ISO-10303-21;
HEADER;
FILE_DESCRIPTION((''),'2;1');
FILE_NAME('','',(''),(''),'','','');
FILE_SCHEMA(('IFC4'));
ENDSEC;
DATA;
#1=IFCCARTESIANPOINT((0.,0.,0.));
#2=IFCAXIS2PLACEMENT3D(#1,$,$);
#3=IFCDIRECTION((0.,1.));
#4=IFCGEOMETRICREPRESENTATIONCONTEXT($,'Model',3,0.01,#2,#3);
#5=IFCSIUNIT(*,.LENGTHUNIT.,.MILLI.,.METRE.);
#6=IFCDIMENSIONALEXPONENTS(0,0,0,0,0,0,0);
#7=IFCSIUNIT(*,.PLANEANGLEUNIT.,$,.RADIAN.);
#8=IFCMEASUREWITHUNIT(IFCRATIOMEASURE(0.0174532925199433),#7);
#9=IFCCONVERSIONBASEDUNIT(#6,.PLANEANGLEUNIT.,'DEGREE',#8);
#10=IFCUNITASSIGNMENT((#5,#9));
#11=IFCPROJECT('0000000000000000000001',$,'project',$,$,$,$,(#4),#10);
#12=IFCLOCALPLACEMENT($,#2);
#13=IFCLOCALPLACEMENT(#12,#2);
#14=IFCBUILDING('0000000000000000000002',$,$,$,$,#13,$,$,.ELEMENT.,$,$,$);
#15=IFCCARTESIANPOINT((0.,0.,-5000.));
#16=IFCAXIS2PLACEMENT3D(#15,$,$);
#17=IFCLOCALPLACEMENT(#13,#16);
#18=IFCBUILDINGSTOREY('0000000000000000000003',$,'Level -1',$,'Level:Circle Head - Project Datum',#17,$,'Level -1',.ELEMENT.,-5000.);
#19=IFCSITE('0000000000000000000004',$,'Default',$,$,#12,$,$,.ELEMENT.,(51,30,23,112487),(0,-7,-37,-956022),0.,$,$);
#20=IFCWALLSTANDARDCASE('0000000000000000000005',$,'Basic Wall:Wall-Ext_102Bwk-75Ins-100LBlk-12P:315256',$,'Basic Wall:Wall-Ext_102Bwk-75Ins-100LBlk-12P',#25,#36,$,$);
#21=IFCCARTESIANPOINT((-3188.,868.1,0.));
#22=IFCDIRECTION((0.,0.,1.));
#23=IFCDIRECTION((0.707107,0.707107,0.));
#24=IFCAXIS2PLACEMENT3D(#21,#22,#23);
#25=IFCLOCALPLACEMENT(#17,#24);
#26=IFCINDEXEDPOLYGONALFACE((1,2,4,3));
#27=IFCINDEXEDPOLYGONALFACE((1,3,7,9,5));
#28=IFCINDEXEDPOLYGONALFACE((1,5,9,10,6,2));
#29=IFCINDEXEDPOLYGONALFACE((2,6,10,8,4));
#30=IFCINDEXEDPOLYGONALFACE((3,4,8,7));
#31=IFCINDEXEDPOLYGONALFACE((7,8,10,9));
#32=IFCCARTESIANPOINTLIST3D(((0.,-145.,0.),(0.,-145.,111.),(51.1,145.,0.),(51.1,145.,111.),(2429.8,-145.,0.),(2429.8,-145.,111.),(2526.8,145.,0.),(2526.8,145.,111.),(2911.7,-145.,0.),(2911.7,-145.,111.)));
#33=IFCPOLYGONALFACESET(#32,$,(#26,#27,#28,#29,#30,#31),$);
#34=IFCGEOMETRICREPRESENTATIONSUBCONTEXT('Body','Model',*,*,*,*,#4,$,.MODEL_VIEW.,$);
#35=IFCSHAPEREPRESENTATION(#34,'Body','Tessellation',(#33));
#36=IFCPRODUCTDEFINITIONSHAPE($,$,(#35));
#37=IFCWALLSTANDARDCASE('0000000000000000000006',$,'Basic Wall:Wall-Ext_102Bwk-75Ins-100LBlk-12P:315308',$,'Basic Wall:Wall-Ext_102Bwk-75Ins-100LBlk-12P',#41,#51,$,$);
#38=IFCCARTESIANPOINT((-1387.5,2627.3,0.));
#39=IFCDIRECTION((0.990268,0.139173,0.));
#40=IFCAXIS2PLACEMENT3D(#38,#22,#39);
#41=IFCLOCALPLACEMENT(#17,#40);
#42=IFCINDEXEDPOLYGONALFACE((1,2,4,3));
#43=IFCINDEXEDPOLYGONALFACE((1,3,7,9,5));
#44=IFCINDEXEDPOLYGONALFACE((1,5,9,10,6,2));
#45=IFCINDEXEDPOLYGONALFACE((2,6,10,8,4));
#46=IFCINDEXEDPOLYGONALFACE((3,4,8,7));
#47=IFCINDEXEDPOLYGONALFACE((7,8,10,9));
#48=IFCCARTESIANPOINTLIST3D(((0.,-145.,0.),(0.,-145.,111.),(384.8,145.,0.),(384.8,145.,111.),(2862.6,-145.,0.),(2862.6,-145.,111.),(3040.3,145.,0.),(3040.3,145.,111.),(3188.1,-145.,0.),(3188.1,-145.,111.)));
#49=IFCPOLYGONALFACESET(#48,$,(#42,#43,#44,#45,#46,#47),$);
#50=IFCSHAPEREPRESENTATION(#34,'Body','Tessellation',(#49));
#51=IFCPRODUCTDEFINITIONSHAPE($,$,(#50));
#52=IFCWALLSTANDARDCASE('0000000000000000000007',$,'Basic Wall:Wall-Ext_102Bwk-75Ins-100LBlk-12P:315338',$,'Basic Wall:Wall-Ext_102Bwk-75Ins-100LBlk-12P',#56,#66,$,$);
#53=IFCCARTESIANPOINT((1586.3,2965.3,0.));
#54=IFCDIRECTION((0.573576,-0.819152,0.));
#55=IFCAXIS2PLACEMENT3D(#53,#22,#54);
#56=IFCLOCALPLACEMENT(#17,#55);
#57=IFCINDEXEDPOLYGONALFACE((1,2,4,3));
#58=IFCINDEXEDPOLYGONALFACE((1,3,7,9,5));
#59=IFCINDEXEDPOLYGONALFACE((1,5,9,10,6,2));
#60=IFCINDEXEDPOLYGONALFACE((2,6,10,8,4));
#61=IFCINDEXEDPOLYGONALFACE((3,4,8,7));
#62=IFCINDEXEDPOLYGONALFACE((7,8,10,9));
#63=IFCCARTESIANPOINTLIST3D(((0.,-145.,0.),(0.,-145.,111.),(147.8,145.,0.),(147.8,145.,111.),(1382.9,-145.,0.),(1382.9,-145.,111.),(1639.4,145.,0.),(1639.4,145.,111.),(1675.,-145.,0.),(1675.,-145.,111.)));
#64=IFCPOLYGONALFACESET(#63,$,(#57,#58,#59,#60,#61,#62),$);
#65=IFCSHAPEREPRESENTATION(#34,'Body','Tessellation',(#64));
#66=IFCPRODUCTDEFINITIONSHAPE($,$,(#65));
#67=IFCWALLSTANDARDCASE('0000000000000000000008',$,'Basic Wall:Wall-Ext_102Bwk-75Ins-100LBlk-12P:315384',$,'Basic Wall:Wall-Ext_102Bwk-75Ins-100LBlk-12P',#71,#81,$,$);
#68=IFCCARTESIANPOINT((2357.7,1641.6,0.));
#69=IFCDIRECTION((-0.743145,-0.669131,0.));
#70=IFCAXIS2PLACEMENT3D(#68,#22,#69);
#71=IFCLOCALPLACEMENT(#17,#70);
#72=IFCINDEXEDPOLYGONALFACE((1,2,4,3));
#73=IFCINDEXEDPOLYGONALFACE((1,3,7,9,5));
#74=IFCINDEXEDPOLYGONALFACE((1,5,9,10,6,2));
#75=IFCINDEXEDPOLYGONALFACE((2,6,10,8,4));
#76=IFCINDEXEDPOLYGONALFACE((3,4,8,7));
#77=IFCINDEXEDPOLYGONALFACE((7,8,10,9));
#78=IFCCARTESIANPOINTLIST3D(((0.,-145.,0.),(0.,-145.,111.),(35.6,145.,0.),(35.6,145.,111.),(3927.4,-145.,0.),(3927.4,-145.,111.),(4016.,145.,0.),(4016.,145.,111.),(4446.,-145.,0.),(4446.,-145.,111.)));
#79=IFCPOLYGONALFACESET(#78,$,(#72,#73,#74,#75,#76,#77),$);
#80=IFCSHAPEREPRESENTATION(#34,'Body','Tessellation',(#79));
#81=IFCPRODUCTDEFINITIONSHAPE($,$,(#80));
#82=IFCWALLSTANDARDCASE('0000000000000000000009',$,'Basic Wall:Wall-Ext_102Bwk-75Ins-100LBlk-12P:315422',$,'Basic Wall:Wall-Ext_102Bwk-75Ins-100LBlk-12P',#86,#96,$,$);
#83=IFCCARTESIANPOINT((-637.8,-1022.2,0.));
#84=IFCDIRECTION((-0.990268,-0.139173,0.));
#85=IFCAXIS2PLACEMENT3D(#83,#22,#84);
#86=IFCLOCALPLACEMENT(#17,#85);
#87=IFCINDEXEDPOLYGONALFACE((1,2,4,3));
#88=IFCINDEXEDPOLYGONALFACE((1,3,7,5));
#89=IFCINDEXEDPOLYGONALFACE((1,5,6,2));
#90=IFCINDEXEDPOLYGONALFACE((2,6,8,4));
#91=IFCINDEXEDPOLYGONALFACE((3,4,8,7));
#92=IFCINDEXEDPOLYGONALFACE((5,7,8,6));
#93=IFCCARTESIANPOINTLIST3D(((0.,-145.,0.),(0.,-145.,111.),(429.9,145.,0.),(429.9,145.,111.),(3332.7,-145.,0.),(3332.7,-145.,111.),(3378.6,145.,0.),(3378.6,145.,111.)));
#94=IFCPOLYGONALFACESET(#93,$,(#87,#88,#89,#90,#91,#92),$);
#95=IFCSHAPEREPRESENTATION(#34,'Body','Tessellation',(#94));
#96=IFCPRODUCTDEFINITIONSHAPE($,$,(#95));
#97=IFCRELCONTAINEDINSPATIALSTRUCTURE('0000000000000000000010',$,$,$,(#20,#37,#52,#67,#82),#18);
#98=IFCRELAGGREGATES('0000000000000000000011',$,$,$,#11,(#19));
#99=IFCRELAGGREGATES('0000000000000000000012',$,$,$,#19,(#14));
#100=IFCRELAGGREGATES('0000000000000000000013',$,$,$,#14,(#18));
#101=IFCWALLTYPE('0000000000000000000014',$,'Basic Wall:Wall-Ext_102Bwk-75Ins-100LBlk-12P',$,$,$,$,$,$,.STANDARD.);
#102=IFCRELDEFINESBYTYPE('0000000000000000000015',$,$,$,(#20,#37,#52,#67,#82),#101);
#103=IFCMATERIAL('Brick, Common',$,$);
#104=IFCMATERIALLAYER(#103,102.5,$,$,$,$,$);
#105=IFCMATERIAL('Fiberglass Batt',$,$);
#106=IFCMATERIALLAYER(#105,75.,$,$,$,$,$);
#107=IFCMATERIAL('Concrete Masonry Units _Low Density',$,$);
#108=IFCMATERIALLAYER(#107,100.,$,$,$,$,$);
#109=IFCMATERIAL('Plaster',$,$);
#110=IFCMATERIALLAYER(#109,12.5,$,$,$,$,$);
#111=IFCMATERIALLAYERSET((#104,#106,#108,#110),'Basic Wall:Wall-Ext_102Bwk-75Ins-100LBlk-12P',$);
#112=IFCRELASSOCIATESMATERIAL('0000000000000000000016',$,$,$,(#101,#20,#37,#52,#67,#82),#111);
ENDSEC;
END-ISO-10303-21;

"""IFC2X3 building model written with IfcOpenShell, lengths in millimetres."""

from ifc_helpers import new_model, entity, si_unit, converted_unit, direction, frame, origin, place, context, subcontext, project, spatial, polyline, outline, extrude, material, layer, layer_set, layer_usage, type_object, element, save


model = new_model("IFC2X3")

# Units and contexts
model_context = context("Model", 3, precision=0.01, world=origin(), true_north=direction((0.0, 1.0)))
body_context = subcontext(model_context, "Body", "Model", "MODEL_VIEW")
ifc_project = project(units=[si_unit("LENGTHUNIT", "METRE", prefix="MILLI"), converted_unit("PLANEANGLEUNIT", "DEGREE", entity("IfcRatioMeasure", 0.0174532925199433), si_unit("PLANEANGLEUNIT", "RADIAN"), dimensions=[0, 0, 0, 0, 0, 0, 0])], contexts=[model_context])

# Site, building, storey
site_placement = place(None, origin())
site = spatial("IfcSite", under=ifc_project, at=site_placement, Name="Default", CompositionType="ELEMENT", RefLatitude=(51, 30, 23, 112487), RefLongitude=(0, -7, -37, -956022), RefElevation=0.0)
building_placement = place(site_placement, origin())
building = spatial("IfcBuilding", under=site, at=building_placement, CompositionType="ELEMENT")
storey_placement = place(building_placement, frame((0.0, 0.0, -5000.0)))
storey = spatial("IfcBuildingStorey", under=building, at=storey_placement, Name="Level -1", ObjectType="Level:Circle Head - Project Datum", LongName="Level -1", CompositionType="ELEMENT", Elevation=-5000.0)

# Walls
ifc_material_1 = material(Name="Brick, Common")
ifc_layer_1 = layer(ifc_material_1, 102.5)
ifc_material_2 = material(Name="Fiberglass Batt")
ifc_layer_2 = layer(ifc_material_2, 75.0)
ifc_material_3 = material(Name="Concrete Masonry Units _Low Density")
ifc_layer_3 = layer(ifc_material_3, 100.0)
ifc_material_4 = material(Name="Plaster")
ifc_layer_4 = layer(ifc_material_4, 12.5)
ifc_layer_set_1 = layer_set([ifc_layer_1, ifc_layer_2, ifc_layer_3, ifc_layer_4], Name="Basic Wall:Wall-Ext_102Bwk-75Ins-100LBlk-12P")
wall_type = type_object("IfcWallType", Name="Basic Wall:Wall-Ext_102Bwk-75Ins-100LBlk-12P", PredefinedType="STANDARD", material=ifc_layer_set_1)
ifc_layer_usage_1 = layer_usage(ifc_layer_set_1, "AXIS2", "NEGATIVE", 145.0)
wall_1_placement = place(storey_placement, frame((-3188.0, 868.1, 0.0), z_axis=(0.0, 0.0, 1.0), x_axis=(0.707107, 0.707107, 0.0)))
element("IfcWallStandardCase", 1, at=wall_1_placement, inside=storey, type_object=wall_type, material=ifc_layer_usage_1, Name="Basic Wall:Wall-Ext_102Bwk-75Ins-100LBlk-12P:315256", ObjectType="Basic Wall:Wall-Ext_102Bwk-75Ins-100LBlk-12P", context=body_context, shape_type="SweptSolid", body=[
    extrude(outline(polyline([(2911.7, -145.0), (2526.8, 145.0), (51.1, 145.0), (0.0, -145.0), (2429.8, -145.0), (2911.7, -145.0)])), origin(), (0.0, 0.0, 1.0), 111.0),
])
ifc_layer_usage_2 = layer_usage(ifc_layer_set_1, "AXIS2", "NEGATIVE", 145.0)
wall_2_placement = place(storey_placement, frame((-1387.5, 2627.3, 0.0), z_axis=(0.0, 0.0, 1.0), x_axis=(0.990268, 0.139173, 0.0)))
element("IfcWallStandardCase", 2, at=wall_2_placement, inside=storey, type_object=wall_type, material=ifc_layer_usage_2, Name="Basic Wall:Wall-Ext_102Bwk-75Ins-100LBlk-12P:315308", ObjectType="Basic Wall:Wall-Ext_102Bwk-75Ins-100LBlk-12P", context=body_context, shape_type="SweptSolid", body=[
    extrude(outline(polyline([(3188.1, -145.0), (3040.3, 145.0), (384.8, 145.0), (0.0, -145.0), (2862.6, -145.0), (3188.1, -145.0)])), origin(), (0.0, 0.0, 1.0), 111.0),
])
ifc_layer_usage_3 = layer_usage(ifc_layer_set_1, "AXIS2", "NEGATIVE", 145.0)
wall_3_placement = place(storey_placement, frame((1586.3, 2965.3, 0.0), z_axis=(0.0, 0.0, 1.0), x_axis=(0.573576, -0.819152, 0.0)))
element("IfcWallStandardCase", 3, at=wall_3_placement, inside=storey, type_object=wall_type, material=ifc_layer_usage_3, Name="Basic Wall:Wall-Ext_102Bwk-75Ins-100LBlk-12P:315338", ObjectType="Basic Wall:Wall-Ext_102Bwk-75Ins-100LBlk-12P", context=body_context, shape_type="SweptSolid", body=[
    extrude(outline(polyline([(1675.0, -145.0), (1639.4, 145.0), (147.8, 145.0), (0.0, -145.0), (1382.9, -145.0), (1675.0, -145.0)])), origin(), (0.0, 0.0, 1.0), 111.0),
])
ifc_layer_usage_4 = layer_usage(ifc_layer_set_1, "AXIS2", "NEGATIVE", 145.0)
wall_4_placement = place(storey_placement, frame((2357.7, 1641.6, 0.0), z_axis=(0.0, 0.0, 1.0), x_axis=(-0.743145, -0.669131, 0.0)))
element("IfcWallStandardCase", 4, at=wall_4_placement, inside=storey, type_object=wall_type, material=ifc_layer_usage_4, Name="Basic Wall:Wall-Ext_102Bwk-75Ins-100LBlk-12P:315384", ObjectType="Basic Wall:Wall-Ext_102Bwk-75Ins-100LBlk-12P", context=body_context, shape_type="SweptSolid", body=[
    extrude(outline(polyline([(4446.0, -145.0), (4016.0, 145.0), (35.6, 145.0), (0.0, -145.0), (3927.4, -145.0), (4446.0, -145.0)])), origin(), (0.0, 0.0, 1.0), 111.0),
])
ifc_layer_usage_5 = layer_usage(ifc_layer_set_1, "AXIS2", "NEGATIVE", 145.0)
wall_5_placement = place(storey_placement, frame((-637.8, -1022.2, 0.0), z_axis=(0.0, 0.0, 1.0), x_axis=(-0.990268, -0.139173, 0.0)))
element("IfcWallStandardCase", 5, at=wall_5_placement, inside=storey, type_object=wall_type, material=ifc_layer_usage_5, Name="Basic Wall:Wall-Ext_102Bwk-75Ins-100LBlk-12P:315422", ObjectType="Basic Wall:Wall-Ext_102Bwk-75Ins-100LBlk-12P", context=body_context, shape_type="SweptSolid", body=[
    extrude(outline(polyline([(3332.7, -145.0), (3378.6, 145.0), (429.9, 145.0), (0.0, -145.0), (3332.7, -145.0)])), origin(), (0.0, 0.0, 1.0), 111.0),
])

save(model, "model.ifc")
